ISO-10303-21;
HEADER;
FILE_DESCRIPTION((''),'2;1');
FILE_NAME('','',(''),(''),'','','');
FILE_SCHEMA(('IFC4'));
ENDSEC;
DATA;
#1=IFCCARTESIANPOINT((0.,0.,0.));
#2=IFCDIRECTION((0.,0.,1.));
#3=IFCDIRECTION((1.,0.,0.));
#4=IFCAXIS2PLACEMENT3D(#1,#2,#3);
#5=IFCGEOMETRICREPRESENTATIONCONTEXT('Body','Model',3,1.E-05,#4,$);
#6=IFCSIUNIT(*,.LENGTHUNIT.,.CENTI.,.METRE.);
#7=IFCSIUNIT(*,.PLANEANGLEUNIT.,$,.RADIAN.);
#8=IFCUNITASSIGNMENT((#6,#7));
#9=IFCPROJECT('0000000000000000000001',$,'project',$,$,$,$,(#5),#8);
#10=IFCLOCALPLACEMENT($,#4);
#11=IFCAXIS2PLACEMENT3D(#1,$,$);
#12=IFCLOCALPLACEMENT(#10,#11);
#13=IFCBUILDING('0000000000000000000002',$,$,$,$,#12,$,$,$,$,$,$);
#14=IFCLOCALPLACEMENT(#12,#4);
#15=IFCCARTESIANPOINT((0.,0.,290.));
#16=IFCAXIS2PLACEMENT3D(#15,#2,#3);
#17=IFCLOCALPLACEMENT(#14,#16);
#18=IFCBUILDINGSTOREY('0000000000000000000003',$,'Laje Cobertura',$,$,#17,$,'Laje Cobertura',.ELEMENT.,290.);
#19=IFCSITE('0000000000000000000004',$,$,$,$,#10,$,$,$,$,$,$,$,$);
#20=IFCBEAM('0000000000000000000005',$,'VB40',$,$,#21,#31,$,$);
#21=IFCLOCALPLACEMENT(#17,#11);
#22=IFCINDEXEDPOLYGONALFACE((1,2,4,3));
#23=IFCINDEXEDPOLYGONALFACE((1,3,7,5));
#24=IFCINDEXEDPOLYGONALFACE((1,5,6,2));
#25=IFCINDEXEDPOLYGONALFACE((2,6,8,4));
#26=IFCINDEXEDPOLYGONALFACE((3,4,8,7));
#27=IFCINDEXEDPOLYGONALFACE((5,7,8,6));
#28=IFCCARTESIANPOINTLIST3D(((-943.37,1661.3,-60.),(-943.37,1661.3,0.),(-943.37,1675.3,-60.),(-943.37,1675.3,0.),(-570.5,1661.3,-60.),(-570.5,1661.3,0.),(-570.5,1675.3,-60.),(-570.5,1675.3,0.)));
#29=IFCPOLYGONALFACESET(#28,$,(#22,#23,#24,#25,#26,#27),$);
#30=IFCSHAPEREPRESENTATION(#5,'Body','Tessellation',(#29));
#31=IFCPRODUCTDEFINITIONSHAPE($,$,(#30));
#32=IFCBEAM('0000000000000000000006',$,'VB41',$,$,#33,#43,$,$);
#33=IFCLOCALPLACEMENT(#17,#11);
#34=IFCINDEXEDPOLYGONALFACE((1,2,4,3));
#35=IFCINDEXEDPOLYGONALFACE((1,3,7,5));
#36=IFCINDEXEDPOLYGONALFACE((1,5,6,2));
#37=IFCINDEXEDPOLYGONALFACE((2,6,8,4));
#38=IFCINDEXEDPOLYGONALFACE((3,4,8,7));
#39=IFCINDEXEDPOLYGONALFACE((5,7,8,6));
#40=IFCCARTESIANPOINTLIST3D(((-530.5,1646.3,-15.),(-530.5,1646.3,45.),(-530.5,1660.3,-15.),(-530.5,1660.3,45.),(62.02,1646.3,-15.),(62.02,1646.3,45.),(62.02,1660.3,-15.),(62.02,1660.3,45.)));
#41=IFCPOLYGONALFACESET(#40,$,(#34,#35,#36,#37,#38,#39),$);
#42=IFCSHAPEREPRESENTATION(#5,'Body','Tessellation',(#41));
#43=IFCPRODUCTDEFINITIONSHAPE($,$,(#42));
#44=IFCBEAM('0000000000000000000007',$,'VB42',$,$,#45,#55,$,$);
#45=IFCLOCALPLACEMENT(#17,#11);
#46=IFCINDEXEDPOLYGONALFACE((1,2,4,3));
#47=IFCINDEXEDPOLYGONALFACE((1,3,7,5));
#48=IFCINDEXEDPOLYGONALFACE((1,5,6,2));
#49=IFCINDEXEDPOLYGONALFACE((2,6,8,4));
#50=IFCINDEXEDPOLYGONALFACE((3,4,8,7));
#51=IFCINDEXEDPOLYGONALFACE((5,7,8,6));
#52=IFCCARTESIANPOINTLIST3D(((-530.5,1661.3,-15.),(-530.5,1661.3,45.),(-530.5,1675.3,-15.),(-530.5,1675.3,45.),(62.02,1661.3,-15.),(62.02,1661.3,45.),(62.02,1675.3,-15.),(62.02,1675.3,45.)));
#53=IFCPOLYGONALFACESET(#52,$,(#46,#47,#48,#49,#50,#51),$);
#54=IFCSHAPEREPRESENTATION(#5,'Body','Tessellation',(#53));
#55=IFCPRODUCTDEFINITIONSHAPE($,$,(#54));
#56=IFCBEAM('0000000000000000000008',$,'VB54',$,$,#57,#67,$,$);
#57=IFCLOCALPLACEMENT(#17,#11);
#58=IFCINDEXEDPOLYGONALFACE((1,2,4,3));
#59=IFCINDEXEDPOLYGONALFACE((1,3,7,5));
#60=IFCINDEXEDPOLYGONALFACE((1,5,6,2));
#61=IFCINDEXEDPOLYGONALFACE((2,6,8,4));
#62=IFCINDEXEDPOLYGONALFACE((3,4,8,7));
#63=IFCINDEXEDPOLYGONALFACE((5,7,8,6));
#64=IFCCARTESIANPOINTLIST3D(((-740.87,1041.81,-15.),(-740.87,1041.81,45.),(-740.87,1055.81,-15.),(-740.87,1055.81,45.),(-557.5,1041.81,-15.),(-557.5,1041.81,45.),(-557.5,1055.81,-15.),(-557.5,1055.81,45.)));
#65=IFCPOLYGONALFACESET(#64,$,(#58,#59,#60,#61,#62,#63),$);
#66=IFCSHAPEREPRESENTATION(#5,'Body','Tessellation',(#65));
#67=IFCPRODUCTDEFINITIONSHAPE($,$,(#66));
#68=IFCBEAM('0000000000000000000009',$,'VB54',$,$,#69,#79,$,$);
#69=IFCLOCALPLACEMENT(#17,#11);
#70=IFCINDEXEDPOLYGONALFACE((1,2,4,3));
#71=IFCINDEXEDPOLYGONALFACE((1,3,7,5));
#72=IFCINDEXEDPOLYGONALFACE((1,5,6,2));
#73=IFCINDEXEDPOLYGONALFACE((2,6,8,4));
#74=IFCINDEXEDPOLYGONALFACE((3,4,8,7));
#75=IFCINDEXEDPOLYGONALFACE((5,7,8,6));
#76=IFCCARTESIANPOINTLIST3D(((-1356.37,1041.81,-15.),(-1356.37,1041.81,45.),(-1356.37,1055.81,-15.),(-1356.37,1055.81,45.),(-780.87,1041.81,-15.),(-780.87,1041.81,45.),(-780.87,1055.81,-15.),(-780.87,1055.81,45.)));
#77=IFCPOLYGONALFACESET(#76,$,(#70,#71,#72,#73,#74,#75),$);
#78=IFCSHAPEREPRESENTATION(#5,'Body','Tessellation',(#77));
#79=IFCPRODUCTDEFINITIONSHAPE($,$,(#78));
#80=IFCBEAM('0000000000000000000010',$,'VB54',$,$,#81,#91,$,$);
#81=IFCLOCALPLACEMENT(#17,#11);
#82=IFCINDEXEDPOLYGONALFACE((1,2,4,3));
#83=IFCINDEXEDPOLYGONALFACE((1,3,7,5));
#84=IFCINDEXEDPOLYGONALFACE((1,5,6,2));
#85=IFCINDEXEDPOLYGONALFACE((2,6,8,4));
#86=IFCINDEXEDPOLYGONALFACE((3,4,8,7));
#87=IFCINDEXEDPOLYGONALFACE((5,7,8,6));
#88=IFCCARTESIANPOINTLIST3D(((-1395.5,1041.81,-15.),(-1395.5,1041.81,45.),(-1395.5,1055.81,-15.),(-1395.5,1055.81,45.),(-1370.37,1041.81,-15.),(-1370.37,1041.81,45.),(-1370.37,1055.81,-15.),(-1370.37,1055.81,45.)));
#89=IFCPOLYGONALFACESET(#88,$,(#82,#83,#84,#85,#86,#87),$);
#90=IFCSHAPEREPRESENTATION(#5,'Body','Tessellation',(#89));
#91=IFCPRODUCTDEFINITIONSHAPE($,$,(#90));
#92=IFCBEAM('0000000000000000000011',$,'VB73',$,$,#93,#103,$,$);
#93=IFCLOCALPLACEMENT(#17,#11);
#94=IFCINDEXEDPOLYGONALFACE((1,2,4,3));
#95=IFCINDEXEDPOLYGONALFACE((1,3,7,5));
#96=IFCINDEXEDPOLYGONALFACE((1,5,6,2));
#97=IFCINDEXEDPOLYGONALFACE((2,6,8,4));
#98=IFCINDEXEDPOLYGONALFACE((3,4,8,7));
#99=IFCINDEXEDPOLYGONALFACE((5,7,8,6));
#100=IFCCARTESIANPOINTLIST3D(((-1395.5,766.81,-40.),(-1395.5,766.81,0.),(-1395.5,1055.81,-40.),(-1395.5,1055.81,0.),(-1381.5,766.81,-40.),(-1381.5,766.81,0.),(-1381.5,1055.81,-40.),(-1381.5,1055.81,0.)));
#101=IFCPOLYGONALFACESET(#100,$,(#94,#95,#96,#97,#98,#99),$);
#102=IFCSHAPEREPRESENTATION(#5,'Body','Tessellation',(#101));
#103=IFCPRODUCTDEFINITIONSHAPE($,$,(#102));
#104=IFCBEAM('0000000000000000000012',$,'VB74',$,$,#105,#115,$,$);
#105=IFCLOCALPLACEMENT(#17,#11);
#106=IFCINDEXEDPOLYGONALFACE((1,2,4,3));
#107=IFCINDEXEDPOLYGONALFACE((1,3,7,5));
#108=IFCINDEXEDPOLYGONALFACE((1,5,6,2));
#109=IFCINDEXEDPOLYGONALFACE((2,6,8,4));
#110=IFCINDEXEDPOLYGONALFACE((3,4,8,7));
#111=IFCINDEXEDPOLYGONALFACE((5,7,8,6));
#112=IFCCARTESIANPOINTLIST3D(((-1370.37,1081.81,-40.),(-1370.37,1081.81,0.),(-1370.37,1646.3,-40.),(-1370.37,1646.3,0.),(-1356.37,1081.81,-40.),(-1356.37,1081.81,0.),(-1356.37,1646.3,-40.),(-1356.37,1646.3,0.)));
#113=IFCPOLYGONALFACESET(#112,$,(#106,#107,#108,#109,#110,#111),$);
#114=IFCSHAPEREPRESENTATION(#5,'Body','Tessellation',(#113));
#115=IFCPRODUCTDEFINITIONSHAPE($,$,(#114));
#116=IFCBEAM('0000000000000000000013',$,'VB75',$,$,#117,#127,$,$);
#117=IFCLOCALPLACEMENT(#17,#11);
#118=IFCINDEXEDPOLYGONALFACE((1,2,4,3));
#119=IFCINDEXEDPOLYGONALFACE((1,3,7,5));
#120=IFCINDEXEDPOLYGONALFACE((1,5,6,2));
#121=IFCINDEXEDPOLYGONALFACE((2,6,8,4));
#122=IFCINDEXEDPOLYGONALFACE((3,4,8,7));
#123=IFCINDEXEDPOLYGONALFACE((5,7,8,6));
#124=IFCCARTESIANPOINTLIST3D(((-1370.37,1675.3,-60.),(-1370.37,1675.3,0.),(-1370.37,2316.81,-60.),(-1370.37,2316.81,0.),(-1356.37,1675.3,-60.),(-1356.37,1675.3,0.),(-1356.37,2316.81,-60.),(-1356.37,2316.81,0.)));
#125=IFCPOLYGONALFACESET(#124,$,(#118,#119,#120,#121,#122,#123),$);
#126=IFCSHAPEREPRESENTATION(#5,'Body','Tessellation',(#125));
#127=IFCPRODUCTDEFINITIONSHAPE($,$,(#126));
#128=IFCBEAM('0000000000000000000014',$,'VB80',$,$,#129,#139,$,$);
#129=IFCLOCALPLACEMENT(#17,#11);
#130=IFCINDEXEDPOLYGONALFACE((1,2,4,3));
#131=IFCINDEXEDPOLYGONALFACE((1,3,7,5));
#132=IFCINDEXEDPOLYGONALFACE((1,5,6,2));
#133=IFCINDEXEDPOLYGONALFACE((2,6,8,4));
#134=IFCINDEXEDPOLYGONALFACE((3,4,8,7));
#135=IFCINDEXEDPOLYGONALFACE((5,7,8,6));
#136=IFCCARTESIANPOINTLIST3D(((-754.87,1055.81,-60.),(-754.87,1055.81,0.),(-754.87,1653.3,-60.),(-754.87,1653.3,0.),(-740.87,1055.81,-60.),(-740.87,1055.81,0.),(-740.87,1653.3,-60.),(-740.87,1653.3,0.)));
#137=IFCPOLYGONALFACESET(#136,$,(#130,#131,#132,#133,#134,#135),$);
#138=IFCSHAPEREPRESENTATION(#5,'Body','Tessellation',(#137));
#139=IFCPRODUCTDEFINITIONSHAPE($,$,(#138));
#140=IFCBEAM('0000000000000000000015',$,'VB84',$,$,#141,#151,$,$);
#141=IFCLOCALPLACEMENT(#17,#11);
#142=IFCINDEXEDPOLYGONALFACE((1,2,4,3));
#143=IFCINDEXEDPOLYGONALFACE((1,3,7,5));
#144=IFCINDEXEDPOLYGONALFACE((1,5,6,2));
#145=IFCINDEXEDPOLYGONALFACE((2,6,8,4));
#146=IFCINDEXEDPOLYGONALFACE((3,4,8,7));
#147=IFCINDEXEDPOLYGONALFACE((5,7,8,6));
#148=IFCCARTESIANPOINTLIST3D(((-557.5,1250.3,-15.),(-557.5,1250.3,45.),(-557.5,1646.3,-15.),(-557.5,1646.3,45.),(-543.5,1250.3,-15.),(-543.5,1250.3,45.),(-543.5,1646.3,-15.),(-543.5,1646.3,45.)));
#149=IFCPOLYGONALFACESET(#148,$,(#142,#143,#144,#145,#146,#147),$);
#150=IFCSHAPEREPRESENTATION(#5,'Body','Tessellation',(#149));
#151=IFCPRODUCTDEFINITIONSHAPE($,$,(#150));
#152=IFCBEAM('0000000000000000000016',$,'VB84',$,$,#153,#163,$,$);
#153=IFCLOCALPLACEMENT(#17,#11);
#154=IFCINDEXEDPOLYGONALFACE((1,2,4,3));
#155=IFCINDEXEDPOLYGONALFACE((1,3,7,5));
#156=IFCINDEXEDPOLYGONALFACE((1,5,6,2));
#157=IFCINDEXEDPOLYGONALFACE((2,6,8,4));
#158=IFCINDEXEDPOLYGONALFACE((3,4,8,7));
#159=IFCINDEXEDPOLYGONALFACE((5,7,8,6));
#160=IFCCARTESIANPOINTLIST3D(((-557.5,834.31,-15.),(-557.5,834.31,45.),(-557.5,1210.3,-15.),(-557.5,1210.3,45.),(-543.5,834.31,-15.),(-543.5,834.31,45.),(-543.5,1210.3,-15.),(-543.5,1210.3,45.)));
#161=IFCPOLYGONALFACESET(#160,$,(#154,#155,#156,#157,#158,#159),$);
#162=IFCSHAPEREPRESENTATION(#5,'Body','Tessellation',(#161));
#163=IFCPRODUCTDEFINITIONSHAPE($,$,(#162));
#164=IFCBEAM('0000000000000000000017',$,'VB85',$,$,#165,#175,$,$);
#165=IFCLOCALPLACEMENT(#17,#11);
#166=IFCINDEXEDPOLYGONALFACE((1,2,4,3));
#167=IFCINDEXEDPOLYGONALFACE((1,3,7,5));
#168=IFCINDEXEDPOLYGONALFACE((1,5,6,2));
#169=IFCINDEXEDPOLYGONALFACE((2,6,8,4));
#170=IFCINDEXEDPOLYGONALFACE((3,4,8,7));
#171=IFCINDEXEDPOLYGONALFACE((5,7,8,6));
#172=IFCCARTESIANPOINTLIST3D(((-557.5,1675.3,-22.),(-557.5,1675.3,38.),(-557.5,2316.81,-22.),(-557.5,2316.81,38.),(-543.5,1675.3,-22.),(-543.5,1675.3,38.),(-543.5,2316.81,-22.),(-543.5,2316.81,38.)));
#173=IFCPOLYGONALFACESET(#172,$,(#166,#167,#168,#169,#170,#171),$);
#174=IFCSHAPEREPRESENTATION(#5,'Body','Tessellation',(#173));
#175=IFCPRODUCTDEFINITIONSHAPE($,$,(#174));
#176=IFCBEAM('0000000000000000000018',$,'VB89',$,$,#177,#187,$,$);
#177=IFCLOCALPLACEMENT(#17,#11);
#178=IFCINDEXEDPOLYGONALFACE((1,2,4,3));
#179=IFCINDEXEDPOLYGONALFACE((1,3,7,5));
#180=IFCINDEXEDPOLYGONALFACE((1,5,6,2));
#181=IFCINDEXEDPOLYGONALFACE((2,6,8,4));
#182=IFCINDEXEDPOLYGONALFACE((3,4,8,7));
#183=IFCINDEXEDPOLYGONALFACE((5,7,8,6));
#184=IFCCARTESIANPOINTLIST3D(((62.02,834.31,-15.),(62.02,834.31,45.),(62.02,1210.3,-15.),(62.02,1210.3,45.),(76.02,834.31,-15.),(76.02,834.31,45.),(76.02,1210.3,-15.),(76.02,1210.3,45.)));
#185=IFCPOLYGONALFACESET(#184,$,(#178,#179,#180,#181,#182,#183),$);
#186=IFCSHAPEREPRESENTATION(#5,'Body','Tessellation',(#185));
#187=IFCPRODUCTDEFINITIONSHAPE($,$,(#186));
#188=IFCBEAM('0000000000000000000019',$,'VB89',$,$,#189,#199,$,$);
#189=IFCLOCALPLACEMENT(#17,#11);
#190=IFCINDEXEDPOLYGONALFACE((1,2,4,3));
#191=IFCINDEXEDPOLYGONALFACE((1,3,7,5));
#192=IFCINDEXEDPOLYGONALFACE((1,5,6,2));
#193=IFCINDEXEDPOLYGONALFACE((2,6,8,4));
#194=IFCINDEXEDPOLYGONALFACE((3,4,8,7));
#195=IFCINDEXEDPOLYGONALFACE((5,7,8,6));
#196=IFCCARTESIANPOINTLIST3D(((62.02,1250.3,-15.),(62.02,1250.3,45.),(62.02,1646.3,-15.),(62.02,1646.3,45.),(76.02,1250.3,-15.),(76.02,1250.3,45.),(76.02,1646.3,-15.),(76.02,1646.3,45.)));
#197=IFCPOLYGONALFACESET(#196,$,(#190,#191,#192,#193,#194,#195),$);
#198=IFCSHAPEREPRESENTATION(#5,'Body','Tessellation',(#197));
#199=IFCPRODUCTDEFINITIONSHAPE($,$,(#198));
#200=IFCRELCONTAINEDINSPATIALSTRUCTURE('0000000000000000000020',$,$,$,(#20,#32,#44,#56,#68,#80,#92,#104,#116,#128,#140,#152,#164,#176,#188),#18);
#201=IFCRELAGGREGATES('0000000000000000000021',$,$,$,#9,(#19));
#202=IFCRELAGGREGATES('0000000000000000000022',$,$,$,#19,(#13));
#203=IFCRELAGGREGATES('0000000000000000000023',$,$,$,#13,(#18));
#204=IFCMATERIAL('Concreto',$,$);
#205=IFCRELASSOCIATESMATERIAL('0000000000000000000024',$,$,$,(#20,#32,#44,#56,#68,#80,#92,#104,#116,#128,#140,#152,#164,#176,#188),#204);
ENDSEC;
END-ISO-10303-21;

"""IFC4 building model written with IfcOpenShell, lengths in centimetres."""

from ifc_helpers import new_model, si_unit, frame, origin, origin_with_axes, origin_2d_with_axis, place, context, project, spatial, rectangle, extrude, material, element, save


model = new_model("IFC4")

# Units and contexts
model_context = context("Model", 3, precision=1e-05, world=origin_with_axes(), identifier="Body")
ifc_project = project(units=[si_unit("LENGTHUNIT", "METRE", prefix="CENTI"), si_unit("PLANEANGLEUNIT", "RADIAN")], contexts=[model_context])

# Site, building, storey
site_placement = place(None, origin_with_axes())
site = spatial("IfcSite", under=ifc_project, at=site_placement)
building_placement = place(site_placement, origin())
building = spatial("IfcBuilding", under=site, at=building_placement)
placement = place(building_placement, origin_with_axes())
storey_placement = place(placement, frame((0.0, 0.0, 290.0), z_axis=(0.0, 0.0, 1.0), x_axis=(1.0, 0.0, 0.0)))
storey = spatial("IfcBuildingStorey", under=building, at=storey_placement, Name="Laje Cobertura", LongName="Laje Cobertura", CompositionType="ELEMENT", Elevation=290.0)

# Shared definitions
ifc_material = material(Name="Concreto")

# Beams
beam_1_placement = place(storey_placement, frame((-756.93, 1668.3, 0.0), z_axis=(0.0, 0.0, 1.0), x_axis=(1.0, 0.0, 0.0)))
element("IfcBeam", 1, at=beam_1_placement, inside=storey, material=ifc_material, Name="VB40", context=model_context, shape_type="SolidModel", body=[
    extrude(rectangle(XDim=14.0, YDim=60.0, at=origin_2d_with_axis()), frame((-186.44, 0.0, -30.0), z_axis=(1.0, 0.0, 0.0), x_axis=(0.0, 1.0, 0.0)), (0.0, 0.0, 1.0), 372.87),
])
for number, where, z_axis, x_axis, name in (
    (2, (-234.24, 1653.3, 45.0), (0.0, 0.0, 1.0), (1.0, 0.0, 0.0), "VB41"),
    (3, (-234.24, 1668.3, 45.0), (0.0, 0.0, 1.0), (1.0, 0.0, 0.0), "VB42"),
):
    element("IfcBeam", number, at=place(storey_placement, frame(where, z_axis=z_axis, x_axis=x_axis)), inside=storey, material=ifc_material, Name=name, context=model_context, shape_type="SolidModel", body=[
        extrude(rectangle(XDim=14.0, YDim=60.0, at=origin_2d_with_axis()), frame((-296.26, 0.0, -30.0), z_axis=(1.0, 0.0, 0.0), x_axis=(0.0, 1.0, 0.0)), (0.0, 0.0, 1.0), 592.52),
    ])
beam_2_placement = place(storey_placement, frame((-649.18, 1048.81, 45.0), z_axis=(0.0, 0.0, 1.0), x_axis=(1.0, 0.0, 0.0)))
element("IfcBeam", 4, at=beam_2_placement, inside=storey, material=ifc_material, Name="VB54", context=model_context, shape_type="SolidModel", body=[
    extrude(rectangle(XDim=14.0, YDim=60.0, at=origin_2d_with_axis()), frame((-91.69, 0.0, -30.0), z_axis=(1.0, 0.0, 0.0), x_axis=(0.0, 1.0, 0.0)), (0.0, 0.0, 1.0), 183.37),
])
beam_3_placement = place(storey_placement, frame((-1068.62, 1048.81, 45.0), z_axis=(0.0, 0.0, 1.0), x_axis=(1.0, 0.0, 0.0)))
element("IfcBeam", 5, at=beam_3_placement, inside=storey, material=ifc_material, Name="VB54", context=model_context, shape_type="SolidModel", body=[
    extrude(rectangle(XDim=14.0, YDim=60.0, at=origin_2d_with_axis()), frame((-287.75, 0.0, -30.0), z_axis=(1.0, 0.0, 0.0), x_axis=(0.0, 1.0, 0.0)), (0.0, 0.0, 1.0), 575.5),
])
beam_4_placement = place(storey_placement, frame((-1382.93, 1048.81, 45.0), z_axis=(0.0, 0.0, 1.0), x_axis=(1.0, 0.0, 0.0)))
element("IfcBeam", 6, at=beam_4_placement, inside=storey, material=ifc_material, Name="VB54", context=model_context, shape_type="SolidModel", body=[
    extrude(rectangle(XDim=14.0, YDim=60.0, at=origin_2d_with_axis()), frame((-12.56, 0.0, -30.0), z_axis=(1.0, 0.0, 0.0), x_axis=(0.0, 1.0, 0.0)), (0.0, 0.0, 1.0), 25.13),
])
beam_5_placement = place(storey_placement, frame((-1388.5, 911.31, 0.0), z_axis=(0.0, 0.0, 1.0), x_axis=(1.0, 0.0, 0.0)))
element("IfcBeam", 7, at=beam_5_placement, inside=storey, material=ifc_material, Name="VB73", context=model_context, shape_type="SolidModel", body=[
    extrude(rectangle(XDim=14.0, YDim=40.0, at=origin_2d_with_axis()), frame((0.0, -144.5, -20.0), z_axis=(0.0, 1.0, 0.0), x_axis=(-1.0, 0.0, 0.0)), (0.0, 0.0, 1.0), 289.0),
])
beam_6_placement = place(storey_placement, frame((-1363.37, 1364.06, 0.0), z_axis=(0.0, 0.0, 1.0), x_axis=(1.0, 0.0, 0.0)))
element("IfcBeam", 8, at=beam_6_placement, inside=storey, material=ifc_material, Name="VB74", context=model_context, shape_type="SolidModel", body=[
    extrude(rectangle(XDim=14.0, YDim=40.0, at=origin_2d_with_axis()), frame((0.0, -282.25, -20.0), z_axis=(0.0, 1.0, 0.0), x_axis=(-1.0, 0.0, 0.0)), (0.0, 0.0, 1.0), 564.49),
])
beam_7_placement = place(storey_placement, frame((-1363.37, 1996.06, 0.0), z_axis=(0.0, 0.0, 1.0), x_axis=(1.0, 0.0, 0.0)))
element("IfcBeam", 9, at=beam_7_placement, inside=storey, material=ifc_material, Name="VB75", context=model_context, shape_type="SolidModel", body=[
    extrude(rectangle(XDim=14.0, YDim=60.0, at=origin_2d_with_axis()), frame((0.0, -320.75, -30.0), z_axis=(0.0, 1.0, 0.0), x_axis=(-1.0, 0.0, 0.0)), (0.0, 0.0, 1.0), 641.51),
])
beam_8_placement = place(storey_placement, frame((-747.87, 1354.56, 0.0), z_axis=(0.0, 0.0, 1.0), x_axis=(1.0, 0.0, 0.0)))
element("IfcBeam", 10, at=beam_8_placement, inside=storey, material=ifc_material, Name="VB80", context=model_context, shape_type="SolidModel", body=[
    extrude(rectangle(XDim=14.0, YDim=60.0, at=origin_2d_with_axis()), frame((0.0, -298.75, -30.0), z_axis=(0.0, 1.0, 0.0), x_axis=(-1.0, 0.0, 0.0)), (0.0, 0.0, 1.0), 597.49),
])
beam_9_placement = place(storey_placement, frame((-550.5, 1448.3, 45.0), z_axis=(0.0, 0.0, 1.0), x_axis=(1.0, 0.0, 0.0)))
element("IfcBeam", 11, at=beam_9_placement, inside=storey, material=ifc_material, Name="VB84", context=model_context, shape_type="SolidModel", body=[
    extrude(rectangle(XDim=14.0, YDim=60.0, at=origin_2d_with_axis()), frame((0.0, -198.0, -30.0), z_axis=(0.0, 1.0, 0.0), x_axis=(-1.0, 0.0, 0.0)), (0.0, 0.0, 1.0), 396.0),
])
beam_10_placement = place(storey_placement, frame((-550.5, 1022.3, 45.0), z_axis=(0.0, 0.0, 1.0), x_axis=(1.0, 0.0, 0.0)))
element("IfcBeam", 12, at=beam_10_placement, inside=storey, material=ifc_material, Name="VB84", context=model_context, shape_type="SolidModel", body=[
    extrude(rectangle(XDim=14.0, YDim=60.0, at=origin_2d_with_axis()), frame((0.0, -188.0, -30.0), z_axis=(0.0, 1.0, 0.0), x_axis=(-1.0, 0.0, 0.0)), (0.0, 0.0, 1.0), 375.99),
])
beam_11_placement = place(storey_placement, frame((-550.5, 1996.06, 38.0), z_axis=(0.0, 0.0, 1.0), x_axis=(1.0, 0.0, 0.0)))
element("IfcBeam", 13, at=beam_11_placement, inside=storey, material=ifc_material, Name="VB85", context=model_context, shape_type="SolidModel", body=[
    extrude(rectangle(XDim=14.0, YDim=60.0, at=origin_2d_with_axis()), frame((0.0, -320.75, -30.0), z_axis=(0.0, 1.0, 0.0), x_axis=(-1.0, 0.0, 0.0)), (0.0, 0.0, 1.0), 641.51),
])
beam_12_placement = place(storey_placement, frame((69.02, 1022.3, 45.0), z_axis=(0.0, 0.0, 1.0), x_axis=(1.0, 0.0, 0.0)))
element("IfcBeam", 14, at=beam_12_placement, inside=storey, material=ifc_material, Name="VB89", context=model_context, shape_type="SolidModel", body=[
    extrude(rectangle(XDim=14.0, YDim=60.0, at=origin_2d_with_axis()), frame((0.0, -188.0, -30.0), z_axis=(0.0, 1.0, 0.0), x_axis=(-1.0, 0.0, 0.0)), (0.0, 0.0, 1.0), 375.99),
])
beam_13_placement = place(storey_placement, frame((69.02, 1448.3, 45.0), z_axis=(0.0, 0.0, 1.0), x_axis=(1.0, 0.0, 0.0)))
element("IfcBeam", 15, at=beam_13_placement, inside=storey, material=ifc_material, Name="VB89", context=model_context, shape_type="SolidModel", body=[
    extrude(rectangle(XDim=14.0, YDim=60.0, at=origin_2d_with_axis()), frame((0.0, -198.0, -30.0), z_axis=(0.0, 1.0, 0.0), x_axis=(-1.0, 0.0, 0.0)), (0.0, 0.0, 1.0), 396.0),
])

save(model, "model.ifc")
